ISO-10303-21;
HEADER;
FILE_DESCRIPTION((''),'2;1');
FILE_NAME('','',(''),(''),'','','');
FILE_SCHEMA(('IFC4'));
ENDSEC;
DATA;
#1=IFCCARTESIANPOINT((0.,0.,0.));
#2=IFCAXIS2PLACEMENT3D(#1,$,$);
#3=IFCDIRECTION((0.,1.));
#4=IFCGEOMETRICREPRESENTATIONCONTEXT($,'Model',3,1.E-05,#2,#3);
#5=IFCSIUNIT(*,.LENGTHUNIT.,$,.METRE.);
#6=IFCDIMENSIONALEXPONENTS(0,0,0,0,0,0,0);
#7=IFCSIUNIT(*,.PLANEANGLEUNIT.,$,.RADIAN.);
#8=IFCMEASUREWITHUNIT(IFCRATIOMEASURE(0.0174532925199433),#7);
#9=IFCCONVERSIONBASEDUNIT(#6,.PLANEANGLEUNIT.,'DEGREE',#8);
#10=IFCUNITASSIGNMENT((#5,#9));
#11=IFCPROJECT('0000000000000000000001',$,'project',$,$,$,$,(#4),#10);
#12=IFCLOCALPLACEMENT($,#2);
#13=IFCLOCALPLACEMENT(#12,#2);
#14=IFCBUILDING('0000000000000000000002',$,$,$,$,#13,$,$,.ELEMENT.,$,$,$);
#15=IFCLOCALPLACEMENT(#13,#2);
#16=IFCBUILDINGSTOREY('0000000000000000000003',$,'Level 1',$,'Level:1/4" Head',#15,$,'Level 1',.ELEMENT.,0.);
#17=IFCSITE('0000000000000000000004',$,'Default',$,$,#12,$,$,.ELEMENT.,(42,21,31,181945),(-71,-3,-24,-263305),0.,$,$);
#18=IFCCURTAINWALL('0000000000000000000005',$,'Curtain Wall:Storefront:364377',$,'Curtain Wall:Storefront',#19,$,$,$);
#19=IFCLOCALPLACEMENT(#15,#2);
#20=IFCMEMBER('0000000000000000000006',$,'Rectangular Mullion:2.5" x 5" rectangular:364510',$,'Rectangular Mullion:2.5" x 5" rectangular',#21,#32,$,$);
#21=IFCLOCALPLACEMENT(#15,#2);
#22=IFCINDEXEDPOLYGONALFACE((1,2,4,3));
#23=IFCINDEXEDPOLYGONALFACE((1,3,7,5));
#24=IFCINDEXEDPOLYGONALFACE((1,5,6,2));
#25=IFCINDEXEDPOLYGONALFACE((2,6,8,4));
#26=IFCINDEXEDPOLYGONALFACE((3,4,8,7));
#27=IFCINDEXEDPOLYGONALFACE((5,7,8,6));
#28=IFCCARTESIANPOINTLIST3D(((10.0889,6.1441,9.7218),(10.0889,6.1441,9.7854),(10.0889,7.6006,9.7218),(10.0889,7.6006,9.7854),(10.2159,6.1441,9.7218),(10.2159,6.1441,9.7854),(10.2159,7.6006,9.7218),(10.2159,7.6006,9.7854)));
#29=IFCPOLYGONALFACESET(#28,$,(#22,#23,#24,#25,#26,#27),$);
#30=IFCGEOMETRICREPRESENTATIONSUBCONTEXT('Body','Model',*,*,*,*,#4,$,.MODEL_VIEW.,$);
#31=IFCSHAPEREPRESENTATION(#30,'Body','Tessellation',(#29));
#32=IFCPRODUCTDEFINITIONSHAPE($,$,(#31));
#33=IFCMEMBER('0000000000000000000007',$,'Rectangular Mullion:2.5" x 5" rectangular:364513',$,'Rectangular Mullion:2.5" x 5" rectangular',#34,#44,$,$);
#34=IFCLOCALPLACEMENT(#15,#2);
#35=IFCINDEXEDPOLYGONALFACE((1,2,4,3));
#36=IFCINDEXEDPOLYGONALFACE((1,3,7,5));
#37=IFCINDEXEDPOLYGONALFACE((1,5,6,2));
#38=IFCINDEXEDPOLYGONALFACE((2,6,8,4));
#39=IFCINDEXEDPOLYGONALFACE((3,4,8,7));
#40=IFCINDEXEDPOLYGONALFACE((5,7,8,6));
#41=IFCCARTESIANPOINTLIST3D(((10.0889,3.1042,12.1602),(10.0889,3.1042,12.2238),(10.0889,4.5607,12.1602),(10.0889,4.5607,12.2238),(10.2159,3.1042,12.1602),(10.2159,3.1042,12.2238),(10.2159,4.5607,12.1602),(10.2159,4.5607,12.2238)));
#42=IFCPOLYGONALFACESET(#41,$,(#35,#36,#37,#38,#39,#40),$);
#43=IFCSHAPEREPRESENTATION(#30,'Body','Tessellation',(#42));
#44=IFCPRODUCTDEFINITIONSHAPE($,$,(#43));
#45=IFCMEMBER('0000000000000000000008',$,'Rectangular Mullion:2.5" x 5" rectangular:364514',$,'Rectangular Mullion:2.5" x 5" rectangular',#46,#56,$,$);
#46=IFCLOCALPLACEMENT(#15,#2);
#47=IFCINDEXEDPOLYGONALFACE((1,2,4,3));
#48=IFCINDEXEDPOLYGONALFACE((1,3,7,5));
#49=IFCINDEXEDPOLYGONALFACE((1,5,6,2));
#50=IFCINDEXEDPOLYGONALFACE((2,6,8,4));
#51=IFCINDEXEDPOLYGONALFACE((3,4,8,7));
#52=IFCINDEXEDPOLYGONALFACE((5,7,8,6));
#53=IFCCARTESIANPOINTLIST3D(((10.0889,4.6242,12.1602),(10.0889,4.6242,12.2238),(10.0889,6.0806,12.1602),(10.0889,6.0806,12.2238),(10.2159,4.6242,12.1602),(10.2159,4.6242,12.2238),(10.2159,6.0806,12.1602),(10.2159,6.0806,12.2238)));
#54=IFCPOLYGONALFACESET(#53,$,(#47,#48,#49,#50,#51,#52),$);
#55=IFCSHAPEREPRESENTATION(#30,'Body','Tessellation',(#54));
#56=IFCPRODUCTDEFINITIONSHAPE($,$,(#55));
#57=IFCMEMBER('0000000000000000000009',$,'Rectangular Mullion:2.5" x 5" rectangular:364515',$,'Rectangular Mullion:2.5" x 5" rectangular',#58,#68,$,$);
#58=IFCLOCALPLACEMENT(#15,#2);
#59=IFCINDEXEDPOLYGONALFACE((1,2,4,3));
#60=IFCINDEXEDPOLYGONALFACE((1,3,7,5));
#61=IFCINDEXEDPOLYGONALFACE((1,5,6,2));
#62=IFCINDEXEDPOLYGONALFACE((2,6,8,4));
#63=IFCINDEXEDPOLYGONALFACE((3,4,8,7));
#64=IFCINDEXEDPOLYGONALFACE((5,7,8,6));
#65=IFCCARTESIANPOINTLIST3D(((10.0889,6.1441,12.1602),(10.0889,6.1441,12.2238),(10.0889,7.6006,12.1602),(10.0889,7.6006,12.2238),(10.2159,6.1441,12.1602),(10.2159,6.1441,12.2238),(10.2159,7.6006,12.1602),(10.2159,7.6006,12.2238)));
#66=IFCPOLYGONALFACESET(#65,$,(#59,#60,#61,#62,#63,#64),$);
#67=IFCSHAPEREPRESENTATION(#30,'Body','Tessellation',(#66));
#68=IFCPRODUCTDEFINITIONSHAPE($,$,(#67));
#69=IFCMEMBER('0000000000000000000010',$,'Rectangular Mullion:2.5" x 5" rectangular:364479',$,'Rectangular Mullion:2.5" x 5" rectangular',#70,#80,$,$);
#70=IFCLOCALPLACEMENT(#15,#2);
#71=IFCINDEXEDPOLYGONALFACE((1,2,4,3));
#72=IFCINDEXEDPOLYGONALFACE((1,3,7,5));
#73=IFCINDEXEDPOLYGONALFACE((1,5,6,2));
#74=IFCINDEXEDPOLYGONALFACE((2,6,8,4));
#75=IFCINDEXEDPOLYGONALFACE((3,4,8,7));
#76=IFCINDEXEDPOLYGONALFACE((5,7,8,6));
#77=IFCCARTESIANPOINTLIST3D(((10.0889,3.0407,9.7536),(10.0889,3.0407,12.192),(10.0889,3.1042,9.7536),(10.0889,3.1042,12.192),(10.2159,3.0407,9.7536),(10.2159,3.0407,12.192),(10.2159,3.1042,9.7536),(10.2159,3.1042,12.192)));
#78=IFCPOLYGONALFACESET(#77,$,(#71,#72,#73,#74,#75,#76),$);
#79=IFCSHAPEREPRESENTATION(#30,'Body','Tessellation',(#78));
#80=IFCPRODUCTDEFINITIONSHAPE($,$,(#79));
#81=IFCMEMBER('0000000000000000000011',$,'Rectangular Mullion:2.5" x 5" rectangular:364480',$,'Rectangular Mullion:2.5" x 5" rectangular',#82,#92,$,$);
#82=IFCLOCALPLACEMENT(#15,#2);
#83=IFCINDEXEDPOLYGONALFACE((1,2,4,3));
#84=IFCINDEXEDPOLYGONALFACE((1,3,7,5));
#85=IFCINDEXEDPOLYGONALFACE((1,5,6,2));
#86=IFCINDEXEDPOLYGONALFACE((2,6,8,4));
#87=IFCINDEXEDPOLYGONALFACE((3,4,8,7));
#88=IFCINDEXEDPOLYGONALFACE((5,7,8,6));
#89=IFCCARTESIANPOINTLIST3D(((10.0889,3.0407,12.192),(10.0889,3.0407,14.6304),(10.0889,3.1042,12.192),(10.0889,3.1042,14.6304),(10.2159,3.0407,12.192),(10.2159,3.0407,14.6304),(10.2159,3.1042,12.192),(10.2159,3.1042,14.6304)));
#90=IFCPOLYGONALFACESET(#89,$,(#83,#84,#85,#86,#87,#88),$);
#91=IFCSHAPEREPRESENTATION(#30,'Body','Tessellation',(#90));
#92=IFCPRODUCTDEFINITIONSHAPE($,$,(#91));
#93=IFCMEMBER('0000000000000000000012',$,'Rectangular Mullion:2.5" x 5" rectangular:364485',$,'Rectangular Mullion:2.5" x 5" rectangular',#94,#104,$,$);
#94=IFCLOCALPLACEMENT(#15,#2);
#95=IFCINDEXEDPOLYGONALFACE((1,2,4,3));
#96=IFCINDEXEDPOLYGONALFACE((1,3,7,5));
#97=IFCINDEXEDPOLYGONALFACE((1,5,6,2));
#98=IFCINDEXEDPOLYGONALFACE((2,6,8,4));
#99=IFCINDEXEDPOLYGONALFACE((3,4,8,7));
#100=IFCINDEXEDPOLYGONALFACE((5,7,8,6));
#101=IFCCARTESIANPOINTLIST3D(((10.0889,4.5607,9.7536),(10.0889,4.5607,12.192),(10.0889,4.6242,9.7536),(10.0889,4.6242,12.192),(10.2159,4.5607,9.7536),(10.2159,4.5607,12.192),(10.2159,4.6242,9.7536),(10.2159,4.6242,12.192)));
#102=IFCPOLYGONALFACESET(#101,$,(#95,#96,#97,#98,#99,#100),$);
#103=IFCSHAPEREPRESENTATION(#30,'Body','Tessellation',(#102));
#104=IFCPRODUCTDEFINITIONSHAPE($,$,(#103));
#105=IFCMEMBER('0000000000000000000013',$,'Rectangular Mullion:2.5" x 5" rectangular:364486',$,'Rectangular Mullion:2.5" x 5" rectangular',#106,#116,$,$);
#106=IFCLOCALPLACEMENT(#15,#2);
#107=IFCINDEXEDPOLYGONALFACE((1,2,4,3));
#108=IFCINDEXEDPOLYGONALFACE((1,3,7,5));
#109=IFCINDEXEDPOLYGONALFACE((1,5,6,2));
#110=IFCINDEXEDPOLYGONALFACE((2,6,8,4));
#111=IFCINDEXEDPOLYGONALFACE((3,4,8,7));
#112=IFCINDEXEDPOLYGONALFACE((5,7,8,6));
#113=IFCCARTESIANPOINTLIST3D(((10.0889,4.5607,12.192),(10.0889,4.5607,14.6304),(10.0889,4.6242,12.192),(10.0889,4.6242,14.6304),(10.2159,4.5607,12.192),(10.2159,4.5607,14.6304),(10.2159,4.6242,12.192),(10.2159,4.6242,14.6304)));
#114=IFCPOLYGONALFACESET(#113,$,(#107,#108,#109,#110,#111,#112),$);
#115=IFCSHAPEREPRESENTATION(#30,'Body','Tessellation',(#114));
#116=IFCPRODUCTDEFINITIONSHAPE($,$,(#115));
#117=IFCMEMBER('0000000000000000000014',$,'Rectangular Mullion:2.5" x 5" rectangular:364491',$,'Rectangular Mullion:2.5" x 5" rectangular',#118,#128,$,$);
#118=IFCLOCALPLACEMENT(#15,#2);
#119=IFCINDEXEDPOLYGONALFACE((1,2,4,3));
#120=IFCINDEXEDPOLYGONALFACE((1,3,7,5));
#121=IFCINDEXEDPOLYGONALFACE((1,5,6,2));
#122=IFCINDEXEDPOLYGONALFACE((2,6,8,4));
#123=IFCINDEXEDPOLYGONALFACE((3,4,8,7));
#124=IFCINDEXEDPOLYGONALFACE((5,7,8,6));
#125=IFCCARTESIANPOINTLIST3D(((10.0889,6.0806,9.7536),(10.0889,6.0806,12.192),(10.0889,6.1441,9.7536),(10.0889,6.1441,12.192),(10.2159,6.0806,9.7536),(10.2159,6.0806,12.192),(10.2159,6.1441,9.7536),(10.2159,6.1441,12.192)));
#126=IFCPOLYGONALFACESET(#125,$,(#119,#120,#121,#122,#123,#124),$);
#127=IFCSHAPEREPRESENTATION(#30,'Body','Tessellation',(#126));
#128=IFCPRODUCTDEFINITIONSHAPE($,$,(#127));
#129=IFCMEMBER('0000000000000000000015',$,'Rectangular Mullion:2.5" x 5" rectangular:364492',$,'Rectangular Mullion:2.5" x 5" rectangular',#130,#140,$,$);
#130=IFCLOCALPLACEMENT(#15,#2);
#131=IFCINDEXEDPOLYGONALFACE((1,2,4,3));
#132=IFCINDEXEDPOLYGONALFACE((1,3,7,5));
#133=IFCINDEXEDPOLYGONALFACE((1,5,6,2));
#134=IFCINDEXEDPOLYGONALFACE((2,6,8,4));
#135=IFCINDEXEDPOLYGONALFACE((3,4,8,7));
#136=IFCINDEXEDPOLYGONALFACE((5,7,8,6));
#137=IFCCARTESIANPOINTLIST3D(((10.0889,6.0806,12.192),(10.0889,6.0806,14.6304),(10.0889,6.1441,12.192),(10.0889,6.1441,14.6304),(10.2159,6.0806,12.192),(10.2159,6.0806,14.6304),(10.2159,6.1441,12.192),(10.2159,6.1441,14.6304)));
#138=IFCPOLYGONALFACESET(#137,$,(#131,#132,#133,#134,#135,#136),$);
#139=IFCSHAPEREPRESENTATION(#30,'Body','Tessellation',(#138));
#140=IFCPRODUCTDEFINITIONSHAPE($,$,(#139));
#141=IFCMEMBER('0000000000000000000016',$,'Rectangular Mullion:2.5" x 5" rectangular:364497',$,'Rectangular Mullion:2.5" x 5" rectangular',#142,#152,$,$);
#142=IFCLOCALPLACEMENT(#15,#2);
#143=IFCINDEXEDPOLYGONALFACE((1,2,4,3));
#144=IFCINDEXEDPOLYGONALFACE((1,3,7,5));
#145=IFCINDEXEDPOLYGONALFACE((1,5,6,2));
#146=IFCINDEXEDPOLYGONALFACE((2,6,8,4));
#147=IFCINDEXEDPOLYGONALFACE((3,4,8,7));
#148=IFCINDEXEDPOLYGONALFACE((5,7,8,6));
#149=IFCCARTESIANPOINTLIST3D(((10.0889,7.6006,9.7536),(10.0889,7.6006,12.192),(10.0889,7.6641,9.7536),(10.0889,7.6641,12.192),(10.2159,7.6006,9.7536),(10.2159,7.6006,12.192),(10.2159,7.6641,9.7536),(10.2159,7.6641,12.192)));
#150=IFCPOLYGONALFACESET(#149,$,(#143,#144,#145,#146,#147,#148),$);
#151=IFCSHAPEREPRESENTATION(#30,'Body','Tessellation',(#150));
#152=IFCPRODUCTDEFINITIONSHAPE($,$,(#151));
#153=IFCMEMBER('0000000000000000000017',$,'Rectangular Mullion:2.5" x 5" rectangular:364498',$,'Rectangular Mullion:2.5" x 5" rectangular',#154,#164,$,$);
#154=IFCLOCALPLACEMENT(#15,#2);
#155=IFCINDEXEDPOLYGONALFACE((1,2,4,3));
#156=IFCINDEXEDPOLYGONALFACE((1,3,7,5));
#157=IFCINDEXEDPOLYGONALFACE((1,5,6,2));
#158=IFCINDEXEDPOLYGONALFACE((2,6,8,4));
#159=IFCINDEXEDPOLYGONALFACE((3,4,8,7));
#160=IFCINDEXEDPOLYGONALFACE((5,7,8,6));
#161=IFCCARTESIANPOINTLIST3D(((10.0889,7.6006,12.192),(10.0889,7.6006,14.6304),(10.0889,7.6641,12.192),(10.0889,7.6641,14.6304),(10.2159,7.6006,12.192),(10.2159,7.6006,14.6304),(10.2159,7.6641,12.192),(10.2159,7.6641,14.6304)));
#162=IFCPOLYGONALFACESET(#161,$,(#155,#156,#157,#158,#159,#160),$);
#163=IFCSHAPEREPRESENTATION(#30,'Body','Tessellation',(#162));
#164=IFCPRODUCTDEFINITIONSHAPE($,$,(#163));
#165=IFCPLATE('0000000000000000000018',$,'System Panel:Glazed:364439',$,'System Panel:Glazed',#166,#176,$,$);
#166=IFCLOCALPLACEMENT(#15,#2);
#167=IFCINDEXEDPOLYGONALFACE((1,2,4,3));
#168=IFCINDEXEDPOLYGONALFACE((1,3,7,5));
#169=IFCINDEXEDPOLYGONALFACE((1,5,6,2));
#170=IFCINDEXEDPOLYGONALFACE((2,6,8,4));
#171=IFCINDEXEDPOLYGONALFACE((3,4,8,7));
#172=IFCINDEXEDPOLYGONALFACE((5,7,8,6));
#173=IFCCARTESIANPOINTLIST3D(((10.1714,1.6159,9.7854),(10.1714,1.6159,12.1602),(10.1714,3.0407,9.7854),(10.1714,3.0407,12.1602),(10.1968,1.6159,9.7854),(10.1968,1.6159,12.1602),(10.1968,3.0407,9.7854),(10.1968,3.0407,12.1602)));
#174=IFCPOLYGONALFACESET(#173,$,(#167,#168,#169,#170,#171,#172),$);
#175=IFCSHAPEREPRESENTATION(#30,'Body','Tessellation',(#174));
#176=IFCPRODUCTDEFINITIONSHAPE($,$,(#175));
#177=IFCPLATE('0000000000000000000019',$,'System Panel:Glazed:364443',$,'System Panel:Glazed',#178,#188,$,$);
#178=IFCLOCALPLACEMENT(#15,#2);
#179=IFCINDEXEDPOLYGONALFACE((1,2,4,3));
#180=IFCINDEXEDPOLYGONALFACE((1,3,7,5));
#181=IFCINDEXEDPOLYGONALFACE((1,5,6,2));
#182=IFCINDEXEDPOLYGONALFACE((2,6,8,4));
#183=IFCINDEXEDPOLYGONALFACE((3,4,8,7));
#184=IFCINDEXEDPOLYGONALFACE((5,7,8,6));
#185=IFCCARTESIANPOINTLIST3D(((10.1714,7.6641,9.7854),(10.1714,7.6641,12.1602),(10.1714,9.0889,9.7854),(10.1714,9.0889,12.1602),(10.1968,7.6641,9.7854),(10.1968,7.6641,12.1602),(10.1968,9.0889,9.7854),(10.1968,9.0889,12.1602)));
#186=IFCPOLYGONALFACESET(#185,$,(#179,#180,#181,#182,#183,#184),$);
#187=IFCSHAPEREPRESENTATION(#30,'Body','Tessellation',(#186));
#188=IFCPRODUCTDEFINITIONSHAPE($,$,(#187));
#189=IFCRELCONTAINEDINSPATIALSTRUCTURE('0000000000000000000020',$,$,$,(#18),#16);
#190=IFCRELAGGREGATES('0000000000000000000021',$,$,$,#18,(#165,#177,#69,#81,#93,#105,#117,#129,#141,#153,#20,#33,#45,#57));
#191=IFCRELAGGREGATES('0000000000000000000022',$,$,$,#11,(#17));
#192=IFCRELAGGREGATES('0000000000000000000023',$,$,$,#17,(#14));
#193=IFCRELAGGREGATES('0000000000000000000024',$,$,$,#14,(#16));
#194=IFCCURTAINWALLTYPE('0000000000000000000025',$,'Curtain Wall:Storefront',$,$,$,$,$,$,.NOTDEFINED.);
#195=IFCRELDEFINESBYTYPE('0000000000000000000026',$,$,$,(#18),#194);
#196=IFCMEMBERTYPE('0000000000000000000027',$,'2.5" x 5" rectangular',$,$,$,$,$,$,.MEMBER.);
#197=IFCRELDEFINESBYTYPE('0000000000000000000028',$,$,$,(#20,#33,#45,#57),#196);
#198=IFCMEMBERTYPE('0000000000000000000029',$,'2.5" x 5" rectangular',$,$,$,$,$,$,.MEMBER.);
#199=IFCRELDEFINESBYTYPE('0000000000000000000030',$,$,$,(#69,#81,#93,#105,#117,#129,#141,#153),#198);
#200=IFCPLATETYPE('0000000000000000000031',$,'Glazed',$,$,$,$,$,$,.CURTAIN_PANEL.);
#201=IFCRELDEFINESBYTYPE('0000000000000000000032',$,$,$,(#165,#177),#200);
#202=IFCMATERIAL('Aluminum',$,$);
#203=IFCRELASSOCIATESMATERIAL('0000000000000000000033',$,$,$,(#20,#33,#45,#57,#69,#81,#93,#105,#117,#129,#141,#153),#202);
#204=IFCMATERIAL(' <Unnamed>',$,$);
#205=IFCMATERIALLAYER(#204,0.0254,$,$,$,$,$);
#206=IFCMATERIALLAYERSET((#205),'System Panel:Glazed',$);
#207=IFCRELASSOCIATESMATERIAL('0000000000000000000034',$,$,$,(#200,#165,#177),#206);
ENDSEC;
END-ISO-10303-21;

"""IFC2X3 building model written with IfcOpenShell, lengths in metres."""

from ifc_helpers import new_model, entity, si_unit, converted_unit, direction, frame, frame_2d, origin, origin_2d_with_axis, place, context, subcontext, project, spatial, rectangle, extrude, source, transform, mapped, material, layer, layer_set, layer_usage, type_object, type_shapes, element, aggregate, save


model = new_model("IFC2X3")

# Units and contexts
model_context = context("Model", 3, precision=1e-05, world=origin(), true_north=direction((0.0, 1.0)))
body_context = subcontext(model_context, "Body", "Model", "MODEL_VIEW")
ifc_project = project(units=[si_unit("LENGTHUNIT", "METRE"), converted_unit("PLANEANGLEUNIT", "DEGREE", entity("IfcRatioMeasure", 0.0174532925199433), si_unit("PLANEANGLEUNIT", "RADIAN"), dimensions=[0, 0, 0, 0, 0, 0, 0])], contexts=[model_context])

# Site, building, storey
site_placement = place(None, origin())
site = spatial("IfcSite", under=ifc_project, at=site_placement, Name="Default", CompositionType="ELEMENT", RefLatitude=(42, 21, 31, 181945), RefLongitude=(-71, -3, -24, -263305), RefElevation=0.0)
building_placement = place(site_placement, origin())
building = spatial("IfcBuilding", under=site, at=building_placement, CompositionType="ELEMENT")
storey_placement = place(building_placement, origin())
storey = spatial("IfcBuildingStorey", under=building, at=storey_placement, Name="Level 1", ObjectType="Level:1/4\" Head", LongName="Level 1", CompositionType="ELEMENT", Elevation=0.0)

# Shared definitions
curtain_wall_type = type_object("IfcCurtainWallType", Name="Curtain Wall:Storefront", PredefinedType="NOTDEFINED")
ifc_material_1 = material(Name="Aluminum")

# Curtain wall, members, plates
curtain_wall_1_placement = place(storey_placement, origin())
curtain_wall_1 = element("IfcCurtainWall", 1, at=curtain_wall_1_placement, inside=storey, type_object=curtain_wall_type, Name="Curtain Wall:Storefront:364377", ObjectType="Curtain Wall:Storefront")
member_type_1 = type_object("IfcMemberType", Name="2.5\" x 5\" rectangular", PredefinedType="MEMBER")
shared_shape_1 = source(origin(), body_context, "Body", "SweptSolid", [
    extrude(rectangle(XDim=0.127, YDim=0.0635, at=origin_2d_with_axis()), frame((0.0, 0.0, -1.4565), z_axis=(0.0, 0.0, 1.0), x_axis=(0.0, -1.0, 0.0)), (0.0, 0.0, 1.0), 1.4565),
])
type_shapes(member_type_1, [shared_shape_1])
member_1_placement = place(storey_placement, frame((10.1524, 7.6006, 9.7536), z_axis=(0.0, 1.0, 0.0), x_axis=(0.0, 0.0, 1.0)))
member_1 = element("IfcMember", 2, at=member_1_placement, type_object=member_type_1, material=ifc_material_1, Name="Rectangular Mullion:2.5\" x 5\" rectangular:364510", ObjectType="Rectangular Mullion:2.5\" x 5\" rectangular", context=body_context, shape_type="MappedRepresentation", body=[
    mapped(shared_shape_1, transform((0.0, 0.0, 0.0), scale=1.0)),
])
member_2_placement = place(storey_placement, frame((10.1524, 4.5607, 12.192), z_axis=(0.0, 1.0, 0.0), x_axis=(0.0, 0.0, 1.0)))
member_2 = element("IfcMember", 3, at=member_2_placement, type_object=member_type_1, material=ifc_material_1, Name="Rectangular Mullion:2.5\" x 5\" rectangular:364513", ObjectType="Rectangular Mullion:2.5\" x 5\" rectangular", context=body_context, shape_type="MappedRepresentation", body=[
    mapped(shared_shape_1, transform((0.0, 0.0, 0.0), scale=1.0)),
])
member_3_placement = place(storey_placement, frame((10.1524, 6.0806, 12.192), z_axis=(0.0, 1.0, 0.0), x_axis=(0.0, 0.0, 1.0)))
member_3 = element("IfcMember", 4, at=member_3_placement, type_object=member_type_1, material=ifc_material_1, Name="Rectangular Mullion:2.5\" x 5\" rectangular:364514", ObjectType="Rectangular Mullion:2.5\" x 5\" rectangular", context=body_context, shape_type="MappedRepresentation", body=[
    mapped(shared_shape_1, transform((0.0, 0.0, 0.0), scale=1.0)),
])
member_4_placement = place(storey_placement, frame((10.1524, 7.6006, 12.192), z_axis=(0.0, 1.0, 0.0), x_axis=(0.0, 0.0, 1.0)))
member_4 = element("IfcMember", 5, at=member_4_placement, type_object=member_type_1, material=ifc_material_1, Name="Rectangular Mullion:2.5\" x 5\" rectangular:364515", ObjectType="Rectangular Mullion:2.5\" x 5\" rectangular", context=body_context, shape_type="MappedRepresentation", body=[
    mapped(shared_shape_1, transform((0.0, 0.0, 0.0), scale=1.0)),
])
member_type_2 = type_object("IfcMemberType", Name="2.5\" x 5\" rectangular", PredefinedType="MEMBER")
shared_shape_2 = source(origin(), body_context, "Body", "SweptSolid", [
    extrude(rectangle(XDim=0.127, YDim=0.0635, at=origin_2d_with_axis()), frame((0.0, 0.0, -2.4384), z_axis=(0.0, 0.0, 1.0), x_axis=(0.0, -1.0, 0.0)), (0.0, 0.0, 1.0), 2.4384),
])
type_shapes(member_type_2, [shared_shape_2])
member_5_placement = place(storey_placement, frame((10.1524, 3.0724, 9.7536), z_axis=(0.0, 0.0, -1.0), x_axis=(0.0, 1.0, 0.0)))
member_5 = element("IfcMember", 6, at=member_5_placement, type_object=member_type_2, material=ifc_material_1, Name="Rectangular Mullion:2.5\" x 5\" rectangular:364479", ObjectType="Rectangular Mullion:2.5\" x 5\" rectangular", context=body_context, shape_type="MappedRepresentation", body=[
    mapped(shared_shape_2, transform((0.0, 0.0, 0.0), scale=1.0)),
])
member_6_placement = place(storey_placement, frame((10.1524, 3.0724, 12.192), z_axis=(0.0, 0.0, -1.0), x_axis=(0.0, 1.0, 0.0)))
member_6 = element("IfcMember", 7, at=member_6_placement, type_object=member_type_2, material=ifc_material_1, Name="Rectangular Mullion:2.5\" x 5\" rectangular:364480", ObjectType="Rectangular Mullion:2.5\" x 5\" rectangular", context=body_context, shape_type="MappedRepresentation", body=[
    mapped(shared_shape_2, transform((0.0, 0.0, 0.0), scale=1.0)),
])
member_7_placement = place(storey_placement, frame((10.1524, 4.5924, 9.7536), z_axis=(0.0, 0.0, -1.0), x_axis=(0.0, 1.0, 0.0)))
member_7 = element("IfcMember", 8, at=member_7_placement, type_object=member_type_2, material=ifc_material_1, Name="Rectangular Mullion:2.5\" x 5\" rectangular:364485", ObjectType="Rectangular Mullion:2.5\" x 5\" rectangular", context=body_context, shape_type="MappedRepresentation", body=[
    mapped(shared_shape_2, transform((0.0, 0.0, 0.0), scale=1.0)),
])
member_8_placement = place(storey_placement, frame((10.1524, 4.5924, 12.192), z_axis=(0.0, 0.0, -1.0), x_axis=(0.0, 1.0, 0.0)))
member_8 = element("IfcMember", 9, at=member_8_placement, type_object=member_type_2, material=ifc_material_1, Name="Rectangular Mullion:2.5\" x 5\" rectangular:364486", ObjectType="Rectangular Mullion:2.5\" x 5\" rectangular", context=body_context, shape_type="MappedRepresentation", body=[
    mapped(shared_shape_2, transform((0.0, 0.0, 0.0), scale=1.0)),
])
member_9_placement = place(storey_placement, frame((10.1524, 6.1124, 9.7536), z_axis=(0.0, 0.0, -1.0), x_axis=(0.0, 1.0, 0.0)))
member_9 = element("IfcMember", 10, at=member_9_placement, type_object=member_type_2, material=ifc_material_1, Name="Rectangular Mullion:2.5\" x 5\" rectangular:364491", ObjectType="Rectangular Mullion:2.5\" x 5\" rectangular", context=body_context, shape_type="MappedRepresentation", body=[
    mapped(shared_shape_2, transform((0.0, 0.0, 0.0), scale=1.0)),
])
member_10_placement = place(storey_placement, frame((10.1524, 6.1124, 12.192), z_axis=(0.0, 0.0, -1.0), x_axis=(0.0, 1.0, 0.0)))
member_10 = element("IfcMember", 11, at=member_10_placement, type_object=member_type_2, material=ifc_material_1, Name="Rectangular Mullion:2.5\" x 5\" rectangular:364492", ObjectType="Rectangular Mullion:2.5\" x 5\" rectangular", context=body_context, shape_type="MappedRepresentation", body=[
    mapped(shared_shape_2, transform((0.0, 0.0, 0.0), scale=1.0)),
])
member_11_placement = place(storey_placement, frame((10.1524, 7.6324, 9.7536), z_axis=(0.0, 0.0, -1.0), x_axis=(0.0, 1.0, 0.0)))
member_11 = element("IfcMember", 12, at=member_11_placement, type_object=member_type_2, material=ifc_material_1, Name="Rectangular Mullion:2.5\" x 5\" rectangular:364497", ObjectType="Rectangular Mullion:2.5\" x 5\" rectangular", context=body_context, shape_type="MappedRepresentation", body=[
    mapped(shared_shape_2, transform((0.0, 0.0, 0.0), scale=1.0)),
])
member_12_placement = place(storey_placement, frame((10.1524, 7.6324, 12.192), z_axis=(0.0, 0.0, -1.0), x_axis=(0.0, 1.0, 0.0)))
member_12 = element("IfcMember", 13, at=member_12_placement, type_object=member_type_2, material=ifc_material_1, Name="Rectangular Mullion:2.5\" x 5\" rectangular:364498", ObjectType="Rectangular Mullion:2.5\" x 5\" rectangular", context=body_context, shape_type="MappedRepresentation", body=[
    mapped(shared_shape_2, transform((0.0, 0.0, 0.0), scale=1.0)),
])
ifc_material_2 = material(Name=" <Unnamed>")
ifc_layer = layer(ifc_material_2, 0.0254)
ifc_layer_set = layer_set([ifc_layer], Name="System Panel:Glazed")
ifc_layer_usage_1 = layer_usage(ifc_layer_set, "AXIS3", "POSITIVE", 0.1042)
plate_type_1 = type_object("IfcPlateType", Name="Glazed", PredefinedType="CURTAIN_PANEL", material=ifc_layer_set)
shared_shape_3 = source(origin(), body_context, "Body", "SweptSolid", [
    extrude(rectangle(XDim=0.0254, YDim=1.4248, at=frame_2d((0.0, 0.0), x_axis=(1.0, 0.0))), frame((0.7124, 0.0127, 0.0), z_axis=(0.0, 0.0, 1.0), x_axis=(0.0, 1.0, 0.0)), (0.0, 0.0, 1.0), 2.3749),
])
type_shapes(plate_type_1, [shared_shape_3])
plate_1_placement = place(curtain_wall_1_placement, frame((10.1968, 1.6159, 9.7853), z_axis=(0.0, 0.0, 1.0), x_axis=(0.0, 1.0, 0.0)))
plate_1 = element("IfcPlate", 14, at=plate_1_placement, type_object=plate_type_1, material=ifc_layer_usage_1, Name="System Panel:Glazed:364439", ObjectType="System Panel:Glazed", context=body_context, shape_type="MappedRepresentation", body=[
    mapped(shared_shape_3, transform((0.0, 0.0, 0.0), scale=1.0)),
])
ifc_layer_usage_2 = layer_usage(ifc_layer_set, "AXIS3", "POSITIVE", 0.1042)
plate_2_placement = place(curtain_wall_1_placement, frame((10.1968, 7.6641, 9.7853), z_axis=(0.0, 0.0, 1.0), x_axis=(0.0, 1.0, 0.0)))
plate_2 = element("IfcPlate", 15, at=plate_2_placement, type_object=plate_type_1, material=ifc_layer_usage_2, Name="System Panel:Glazed:364443", ObjectType="System Panel:Glazed", context=body_context, shape_type="MappedRepresentation", body=[
    mapped(shared_shape_3, transform((0.0, 0.0, 0.0), scale=1.0)),
])
aggregate(curtain_wall_1, [plate_1, plate_2, member_5, member_6, member_7, member_8, member_9, member_10, member_11, member_12, member_1, member_2, member_3, member_4])

save(model, "model.ifc")
